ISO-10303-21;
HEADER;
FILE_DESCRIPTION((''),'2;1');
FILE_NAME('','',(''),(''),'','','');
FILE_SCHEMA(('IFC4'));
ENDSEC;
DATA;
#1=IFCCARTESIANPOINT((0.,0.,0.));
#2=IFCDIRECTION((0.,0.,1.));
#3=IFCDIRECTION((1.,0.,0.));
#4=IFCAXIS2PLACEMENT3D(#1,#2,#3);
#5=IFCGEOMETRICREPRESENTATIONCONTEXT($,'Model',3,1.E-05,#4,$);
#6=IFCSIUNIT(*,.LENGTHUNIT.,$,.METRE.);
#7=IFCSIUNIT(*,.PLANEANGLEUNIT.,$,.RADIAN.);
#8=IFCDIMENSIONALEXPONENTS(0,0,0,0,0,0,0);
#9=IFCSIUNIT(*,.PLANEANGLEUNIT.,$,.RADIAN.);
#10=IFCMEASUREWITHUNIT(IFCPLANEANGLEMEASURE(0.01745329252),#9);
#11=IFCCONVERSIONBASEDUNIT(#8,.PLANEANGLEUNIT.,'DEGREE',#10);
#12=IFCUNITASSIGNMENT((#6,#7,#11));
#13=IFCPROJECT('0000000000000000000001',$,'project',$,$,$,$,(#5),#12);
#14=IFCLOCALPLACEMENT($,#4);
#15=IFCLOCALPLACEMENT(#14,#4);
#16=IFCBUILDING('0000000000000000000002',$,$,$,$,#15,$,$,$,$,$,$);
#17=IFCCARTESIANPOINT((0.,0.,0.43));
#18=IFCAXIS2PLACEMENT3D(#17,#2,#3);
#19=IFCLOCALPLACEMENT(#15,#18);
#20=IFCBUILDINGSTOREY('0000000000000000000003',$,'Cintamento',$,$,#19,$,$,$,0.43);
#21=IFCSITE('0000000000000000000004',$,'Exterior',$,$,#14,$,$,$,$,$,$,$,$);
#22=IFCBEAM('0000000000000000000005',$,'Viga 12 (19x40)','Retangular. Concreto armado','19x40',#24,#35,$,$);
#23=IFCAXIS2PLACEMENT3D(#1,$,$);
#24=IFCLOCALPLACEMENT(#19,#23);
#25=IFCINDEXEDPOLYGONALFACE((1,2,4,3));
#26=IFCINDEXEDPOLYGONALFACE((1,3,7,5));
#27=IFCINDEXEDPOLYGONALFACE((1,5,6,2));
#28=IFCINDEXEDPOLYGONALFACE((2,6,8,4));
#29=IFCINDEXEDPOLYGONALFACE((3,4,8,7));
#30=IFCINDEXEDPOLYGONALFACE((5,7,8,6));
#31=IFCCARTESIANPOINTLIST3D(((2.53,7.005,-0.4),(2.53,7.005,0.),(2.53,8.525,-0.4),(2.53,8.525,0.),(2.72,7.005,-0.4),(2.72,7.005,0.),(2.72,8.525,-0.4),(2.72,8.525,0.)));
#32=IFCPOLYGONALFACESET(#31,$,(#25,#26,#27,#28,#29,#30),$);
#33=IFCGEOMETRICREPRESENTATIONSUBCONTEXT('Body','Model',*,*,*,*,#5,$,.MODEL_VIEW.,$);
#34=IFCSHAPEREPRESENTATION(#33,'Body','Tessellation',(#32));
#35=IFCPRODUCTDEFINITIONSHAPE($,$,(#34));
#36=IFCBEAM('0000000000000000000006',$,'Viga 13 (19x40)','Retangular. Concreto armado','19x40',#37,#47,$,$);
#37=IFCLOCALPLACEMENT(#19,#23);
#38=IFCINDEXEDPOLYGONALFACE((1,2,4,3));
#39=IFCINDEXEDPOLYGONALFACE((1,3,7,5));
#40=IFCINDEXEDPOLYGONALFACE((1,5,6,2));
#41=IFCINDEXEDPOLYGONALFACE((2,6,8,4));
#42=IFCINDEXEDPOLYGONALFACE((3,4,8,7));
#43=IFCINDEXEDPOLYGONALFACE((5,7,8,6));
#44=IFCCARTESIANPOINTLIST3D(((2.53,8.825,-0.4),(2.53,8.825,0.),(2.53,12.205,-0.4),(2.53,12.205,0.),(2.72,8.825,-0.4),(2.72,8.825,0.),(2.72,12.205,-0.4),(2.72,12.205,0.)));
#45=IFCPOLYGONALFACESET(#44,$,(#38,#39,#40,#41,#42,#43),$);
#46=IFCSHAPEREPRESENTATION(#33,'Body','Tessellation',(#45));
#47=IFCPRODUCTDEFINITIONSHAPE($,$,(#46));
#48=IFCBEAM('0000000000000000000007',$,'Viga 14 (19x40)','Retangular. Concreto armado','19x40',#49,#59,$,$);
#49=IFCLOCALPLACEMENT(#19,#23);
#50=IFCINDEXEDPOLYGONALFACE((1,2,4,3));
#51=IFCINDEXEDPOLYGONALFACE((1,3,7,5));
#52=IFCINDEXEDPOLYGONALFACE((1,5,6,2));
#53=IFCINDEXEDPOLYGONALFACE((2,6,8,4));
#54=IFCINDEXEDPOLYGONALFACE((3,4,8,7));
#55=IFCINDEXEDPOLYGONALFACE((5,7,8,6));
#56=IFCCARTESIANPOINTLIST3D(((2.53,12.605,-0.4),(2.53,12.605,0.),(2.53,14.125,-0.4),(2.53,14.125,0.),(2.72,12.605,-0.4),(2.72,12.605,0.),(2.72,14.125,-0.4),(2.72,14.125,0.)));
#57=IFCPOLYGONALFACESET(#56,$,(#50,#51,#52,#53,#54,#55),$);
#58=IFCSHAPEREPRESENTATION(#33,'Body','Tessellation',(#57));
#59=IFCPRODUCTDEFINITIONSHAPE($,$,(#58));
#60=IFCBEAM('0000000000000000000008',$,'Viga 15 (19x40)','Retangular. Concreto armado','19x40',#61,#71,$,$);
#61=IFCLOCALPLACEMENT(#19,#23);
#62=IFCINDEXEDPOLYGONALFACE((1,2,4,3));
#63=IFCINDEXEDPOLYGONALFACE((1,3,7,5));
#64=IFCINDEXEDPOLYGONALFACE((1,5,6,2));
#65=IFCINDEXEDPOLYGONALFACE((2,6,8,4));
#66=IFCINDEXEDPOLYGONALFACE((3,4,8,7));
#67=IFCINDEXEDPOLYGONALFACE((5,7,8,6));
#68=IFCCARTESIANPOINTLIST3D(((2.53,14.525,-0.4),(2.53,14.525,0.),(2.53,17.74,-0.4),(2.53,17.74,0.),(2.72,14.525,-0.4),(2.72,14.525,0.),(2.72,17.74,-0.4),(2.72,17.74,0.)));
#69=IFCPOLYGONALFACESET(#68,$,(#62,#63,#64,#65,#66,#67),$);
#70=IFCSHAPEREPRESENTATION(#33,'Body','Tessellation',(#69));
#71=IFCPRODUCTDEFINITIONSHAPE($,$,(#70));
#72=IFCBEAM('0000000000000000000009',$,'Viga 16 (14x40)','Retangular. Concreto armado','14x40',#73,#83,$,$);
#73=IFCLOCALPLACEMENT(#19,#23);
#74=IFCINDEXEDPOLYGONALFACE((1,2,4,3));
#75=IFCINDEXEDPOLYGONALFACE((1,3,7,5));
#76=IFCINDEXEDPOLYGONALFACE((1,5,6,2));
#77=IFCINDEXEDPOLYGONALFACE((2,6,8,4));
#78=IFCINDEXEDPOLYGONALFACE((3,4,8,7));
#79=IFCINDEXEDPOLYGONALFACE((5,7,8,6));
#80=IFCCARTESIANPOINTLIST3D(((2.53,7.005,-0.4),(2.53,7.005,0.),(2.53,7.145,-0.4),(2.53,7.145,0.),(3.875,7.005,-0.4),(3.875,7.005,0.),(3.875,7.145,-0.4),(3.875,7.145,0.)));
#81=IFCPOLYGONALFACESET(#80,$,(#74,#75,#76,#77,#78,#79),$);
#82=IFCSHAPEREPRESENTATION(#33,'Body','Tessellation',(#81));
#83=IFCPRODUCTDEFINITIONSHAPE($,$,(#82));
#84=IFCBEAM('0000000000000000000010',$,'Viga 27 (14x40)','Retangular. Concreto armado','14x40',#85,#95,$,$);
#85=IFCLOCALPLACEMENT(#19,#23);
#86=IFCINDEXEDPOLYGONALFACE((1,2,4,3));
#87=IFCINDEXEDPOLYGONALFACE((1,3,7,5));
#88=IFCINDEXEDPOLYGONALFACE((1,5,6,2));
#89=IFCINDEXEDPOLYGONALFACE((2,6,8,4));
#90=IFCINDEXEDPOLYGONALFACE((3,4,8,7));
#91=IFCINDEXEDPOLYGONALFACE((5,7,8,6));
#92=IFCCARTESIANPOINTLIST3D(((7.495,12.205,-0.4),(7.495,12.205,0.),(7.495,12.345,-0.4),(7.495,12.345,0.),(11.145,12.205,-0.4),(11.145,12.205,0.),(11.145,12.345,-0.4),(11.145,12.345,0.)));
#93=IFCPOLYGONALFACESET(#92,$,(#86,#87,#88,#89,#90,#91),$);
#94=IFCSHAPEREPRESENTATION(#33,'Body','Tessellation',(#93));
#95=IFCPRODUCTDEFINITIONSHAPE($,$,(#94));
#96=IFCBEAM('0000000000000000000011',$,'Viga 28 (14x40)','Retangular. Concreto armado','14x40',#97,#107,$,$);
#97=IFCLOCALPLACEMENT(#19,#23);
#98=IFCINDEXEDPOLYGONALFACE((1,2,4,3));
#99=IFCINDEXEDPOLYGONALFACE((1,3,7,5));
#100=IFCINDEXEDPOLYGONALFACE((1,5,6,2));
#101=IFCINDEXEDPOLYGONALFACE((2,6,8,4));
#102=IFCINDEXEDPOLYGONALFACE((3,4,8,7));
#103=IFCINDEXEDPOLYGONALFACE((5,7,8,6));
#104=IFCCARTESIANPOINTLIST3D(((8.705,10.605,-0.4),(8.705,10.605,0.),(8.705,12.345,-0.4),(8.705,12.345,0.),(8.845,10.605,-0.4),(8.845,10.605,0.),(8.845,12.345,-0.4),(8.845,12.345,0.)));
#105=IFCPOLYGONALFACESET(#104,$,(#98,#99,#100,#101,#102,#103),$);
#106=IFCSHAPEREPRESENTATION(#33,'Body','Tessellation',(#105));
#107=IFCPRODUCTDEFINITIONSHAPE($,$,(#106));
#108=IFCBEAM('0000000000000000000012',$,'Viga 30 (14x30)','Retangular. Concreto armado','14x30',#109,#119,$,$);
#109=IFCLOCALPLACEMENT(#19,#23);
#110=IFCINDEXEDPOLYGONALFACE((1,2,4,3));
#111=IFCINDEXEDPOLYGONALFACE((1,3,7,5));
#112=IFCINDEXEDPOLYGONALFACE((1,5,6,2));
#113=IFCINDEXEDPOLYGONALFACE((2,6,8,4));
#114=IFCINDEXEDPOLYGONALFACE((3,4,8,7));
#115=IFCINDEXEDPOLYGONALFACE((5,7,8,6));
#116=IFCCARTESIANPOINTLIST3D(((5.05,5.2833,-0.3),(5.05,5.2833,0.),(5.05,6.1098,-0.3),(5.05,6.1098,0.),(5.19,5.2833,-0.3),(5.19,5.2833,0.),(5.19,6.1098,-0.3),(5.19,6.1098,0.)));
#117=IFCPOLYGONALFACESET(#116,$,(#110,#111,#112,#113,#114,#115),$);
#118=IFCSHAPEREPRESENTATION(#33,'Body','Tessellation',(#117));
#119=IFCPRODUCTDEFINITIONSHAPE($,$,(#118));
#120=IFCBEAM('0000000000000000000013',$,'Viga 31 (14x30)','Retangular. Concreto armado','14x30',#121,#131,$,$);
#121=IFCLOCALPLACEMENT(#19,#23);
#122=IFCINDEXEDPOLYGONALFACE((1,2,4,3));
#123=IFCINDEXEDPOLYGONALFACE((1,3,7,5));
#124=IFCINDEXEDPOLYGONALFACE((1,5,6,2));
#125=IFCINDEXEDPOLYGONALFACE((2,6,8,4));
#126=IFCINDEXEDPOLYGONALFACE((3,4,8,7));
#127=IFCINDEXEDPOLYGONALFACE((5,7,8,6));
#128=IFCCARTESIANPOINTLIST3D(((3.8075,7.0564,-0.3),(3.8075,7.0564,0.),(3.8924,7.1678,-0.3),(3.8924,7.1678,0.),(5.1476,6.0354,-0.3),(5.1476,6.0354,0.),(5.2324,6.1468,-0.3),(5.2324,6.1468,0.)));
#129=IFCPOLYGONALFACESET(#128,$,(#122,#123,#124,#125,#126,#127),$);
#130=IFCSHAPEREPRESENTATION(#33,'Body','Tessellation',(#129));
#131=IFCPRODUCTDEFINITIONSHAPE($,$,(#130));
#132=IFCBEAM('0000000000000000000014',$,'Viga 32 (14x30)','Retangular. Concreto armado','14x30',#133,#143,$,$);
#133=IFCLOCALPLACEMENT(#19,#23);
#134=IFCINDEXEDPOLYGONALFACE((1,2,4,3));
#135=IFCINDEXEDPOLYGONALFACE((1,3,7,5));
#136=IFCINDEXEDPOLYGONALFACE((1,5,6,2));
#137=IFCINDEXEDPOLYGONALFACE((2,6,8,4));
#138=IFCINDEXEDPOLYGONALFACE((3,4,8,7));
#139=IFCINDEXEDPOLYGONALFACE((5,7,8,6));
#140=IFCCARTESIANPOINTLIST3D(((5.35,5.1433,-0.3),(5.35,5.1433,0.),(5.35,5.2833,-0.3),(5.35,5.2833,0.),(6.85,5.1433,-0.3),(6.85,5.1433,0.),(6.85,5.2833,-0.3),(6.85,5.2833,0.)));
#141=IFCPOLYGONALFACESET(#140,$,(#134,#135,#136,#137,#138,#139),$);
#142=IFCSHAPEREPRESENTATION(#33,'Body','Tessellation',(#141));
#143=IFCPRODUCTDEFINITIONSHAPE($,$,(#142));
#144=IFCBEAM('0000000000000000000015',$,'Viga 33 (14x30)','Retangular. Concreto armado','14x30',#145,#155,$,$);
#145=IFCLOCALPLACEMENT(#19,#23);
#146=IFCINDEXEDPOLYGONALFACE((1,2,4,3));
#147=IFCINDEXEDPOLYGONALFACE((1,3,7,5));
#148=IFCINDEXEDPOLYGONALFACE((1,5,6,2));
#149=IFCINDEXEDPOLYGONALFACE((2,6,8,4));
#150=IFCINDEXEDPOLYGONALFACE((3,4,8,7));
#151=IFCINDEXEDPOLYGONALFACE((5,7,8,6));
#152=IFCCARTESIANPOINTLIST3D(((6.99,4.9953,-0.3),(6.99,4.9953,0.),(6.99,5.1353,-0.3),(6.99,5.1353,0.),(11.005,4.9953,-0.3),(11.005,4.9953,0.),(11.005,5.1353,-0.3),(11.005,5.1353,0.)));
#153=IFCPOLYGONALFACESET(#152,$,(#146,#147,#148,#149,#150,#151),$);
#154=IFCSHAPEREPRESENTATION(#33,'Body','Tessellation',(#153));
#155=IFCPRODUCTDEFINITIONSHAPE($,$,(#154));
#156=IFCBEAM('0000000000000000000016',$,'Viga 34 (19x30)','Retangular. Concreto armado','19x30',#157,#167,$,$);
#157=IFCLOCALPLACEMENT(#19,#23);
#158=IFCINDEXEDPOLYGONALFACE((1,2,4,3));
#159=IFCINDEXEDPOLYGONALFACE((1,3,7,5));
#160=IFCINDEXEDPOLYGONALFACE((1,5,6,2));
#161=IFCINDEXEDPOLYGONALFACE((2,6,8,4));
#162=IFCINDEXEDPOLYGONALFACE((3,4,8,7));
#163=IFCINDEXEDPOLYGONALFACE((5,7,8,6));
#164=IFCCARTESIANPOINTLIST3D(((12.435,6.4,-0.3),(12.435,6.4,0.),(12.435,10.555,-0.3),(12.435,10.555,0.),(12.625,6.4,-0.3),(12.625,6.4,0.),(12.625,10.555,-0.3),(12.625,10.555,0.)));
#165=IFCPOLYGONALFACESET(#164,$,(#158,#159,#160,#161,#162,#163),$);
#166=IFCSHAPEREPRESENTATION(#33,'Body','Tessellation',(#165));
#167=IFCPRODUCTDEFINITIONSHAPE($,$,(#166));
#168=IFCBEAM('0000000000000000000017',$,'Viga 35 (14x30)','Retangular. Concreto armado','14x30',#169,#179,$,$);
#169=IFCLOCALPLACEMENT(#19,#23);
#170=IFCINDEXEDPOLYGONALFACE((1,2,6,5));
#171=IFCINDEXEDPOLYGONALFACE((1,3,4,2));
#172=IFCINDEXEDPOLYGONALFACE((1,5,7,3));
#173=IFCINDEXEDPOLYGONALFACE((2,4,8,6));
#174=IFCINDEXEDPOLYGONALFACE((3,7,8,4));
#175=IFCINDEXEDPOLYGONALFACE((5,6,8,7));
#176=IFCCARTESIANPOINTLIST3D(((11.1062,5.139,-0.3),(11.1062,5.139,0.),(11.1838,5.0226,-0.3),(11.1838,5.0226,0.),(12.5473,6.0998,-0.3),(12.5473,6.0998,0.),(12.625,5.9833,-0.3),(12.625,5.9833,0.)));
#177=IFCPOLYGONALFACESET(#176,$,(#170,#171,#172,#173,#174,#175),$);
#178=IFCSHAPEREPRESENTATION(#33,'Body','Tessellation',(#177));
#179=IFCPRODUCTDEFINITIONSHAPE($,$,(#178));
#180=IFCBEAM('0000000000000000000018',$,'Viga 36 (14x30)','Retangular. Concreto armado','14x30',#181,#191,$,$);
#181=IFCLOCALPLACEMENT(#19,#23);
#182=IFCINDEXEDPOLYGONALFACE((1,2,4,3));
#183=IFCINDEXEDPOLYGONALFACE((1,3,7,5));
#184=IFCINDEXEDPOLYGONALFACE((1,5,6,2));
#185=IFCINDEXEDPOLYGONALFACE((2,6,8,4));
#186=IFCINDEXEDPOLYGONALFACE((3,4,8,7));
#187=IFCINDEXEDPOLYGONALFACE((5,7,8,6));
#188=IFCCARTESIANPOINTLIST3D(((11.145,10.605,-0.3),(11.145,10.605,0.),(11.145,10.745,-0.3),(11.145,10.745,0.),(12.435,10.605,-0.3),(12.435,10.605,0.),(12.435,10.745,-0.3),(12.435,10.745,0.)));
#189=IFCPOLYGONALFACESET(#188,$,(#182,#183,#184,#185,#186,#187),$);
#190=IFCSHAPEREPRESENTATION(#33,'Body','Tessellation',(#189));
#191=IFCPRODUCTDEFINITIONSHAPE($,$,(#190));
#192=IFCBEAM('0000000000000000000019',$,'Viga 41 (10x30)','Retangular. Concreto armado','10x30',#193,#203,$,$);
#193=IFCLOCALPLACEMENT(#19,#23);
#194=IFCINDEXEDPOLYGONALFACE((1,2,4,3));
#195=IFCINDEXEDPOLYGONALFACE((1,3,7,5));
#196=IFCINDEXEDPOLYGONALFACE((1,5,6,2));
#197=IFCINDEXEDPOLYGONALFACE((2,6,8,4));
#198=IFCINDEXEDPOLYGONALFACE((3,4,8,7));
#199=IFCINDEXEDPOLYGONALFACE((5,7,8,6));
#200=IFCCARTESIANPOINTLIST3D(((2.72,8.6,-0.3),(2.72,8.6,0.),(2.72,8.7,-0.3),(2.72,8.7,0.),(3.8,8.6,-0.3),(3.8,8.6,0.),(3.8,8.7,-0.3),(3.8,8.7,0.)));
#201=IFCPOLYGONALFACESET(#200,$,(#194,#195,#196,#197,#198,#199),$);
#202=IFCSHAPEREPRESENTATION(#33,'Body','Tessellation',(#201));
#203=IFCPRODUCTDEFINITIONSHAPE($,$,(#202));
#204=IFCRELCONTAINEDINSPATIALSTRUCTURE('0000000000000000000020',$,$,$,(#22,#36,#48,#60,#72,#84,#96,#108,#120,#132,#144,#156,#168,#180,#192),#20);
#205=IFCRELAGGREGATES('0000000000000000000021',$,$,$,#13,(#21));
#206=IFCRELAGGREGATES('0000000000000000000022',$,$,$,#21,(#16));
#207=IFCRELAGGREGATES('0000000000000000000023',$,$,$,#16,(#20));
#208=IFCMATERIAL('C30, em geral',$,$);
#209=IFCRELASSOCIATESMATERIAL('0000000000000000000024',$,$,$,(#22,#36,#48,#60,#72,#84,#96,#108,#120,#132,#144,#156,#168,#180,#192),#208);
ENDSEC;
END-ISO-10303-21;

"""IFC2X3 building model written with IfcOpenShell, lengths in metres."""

from ifc_helpers import new_model, entity, si_unit, converted_unit, frame, frame_2d, origin_with_axes, place, context, subcontext, project, spatial, rectangle, extrude, material, element, save


model = new_model("IFC2X3")

# Units and contexts
model_context = context("Model", 3, precision=1e-05, world=origin_with_axes())
body_context = subcontext(model_context, "Body", "Model", "MODEL_VIEW")
ifc_project = project(units=[si_unit("LENGTHUNIT", "METRE"), si_unit("PLANEANGLEUNIT", "RADIAN"), converted_unit("PLANEANGLEUNIT", "DEGREE", entity("IfcPlaneAngleMeasure", 0.01745329252), si_unit("PLANEANGLEUNIT", "RADIAN"), dimensions=[0, 0, 0, 0, 0, 0, 0])], contexts=[model_context])

# Site, building, storey
site_placement = place(None, origin_with_axes())
site = spatial("IfcSite", under=ifc_project, at=site_placement, Name="Exterior")
building_placement = place(site_placement, origin_with_axes())
building = spatial("IfcBuilding", under=site, at=building_placement)
storey_placement = place(building_placement, frame((0.0, 0.0, 0.43), z_axis=(0.0, 0.0, 1.0), x_axis=(1.0, 0.0, 0.0)))
storey = spatial("IfcBuildingStorey", under=building, at=storey_placement, Name="Cintamento", Elevation=0.43)

# Beams
ifc_material_1 = material(Name="C30, em geral")
beam_1_placement = place(storey_placement, frame((2.625, 7.005, 0.0), z_axis=(0.0, 1.0, 0.0), x_axis=(-1.0, 0.0, 0.0)))
element("IfcBeam", 1, at=beam_1_placement, inside=storey, material=ifc_material_1, Name="Viga 12 (19x40)", Description="Retangular. Concreto armado", ObjectType="19x40", context=body_context, shape_type="SweptSolid", body=[
    extrude(rectangle(XDim=0.19, YDim=0.4, at=frame_2d((0.0, -0.2), x_axis=(1.0, 0.0))), origin_with_axes(), (0.0, 0.0, 1.0), 1.52),
])
beam_2_placement = place(storey_placement, frame((2.625, 8.825, 0.0), z_axis=(0.0, 1.0, 0.0), x_axis=(-1.0, 0.0, 0.0)))
element("IfcBeam", 2, at=beam_2_placement, inside=storey, material=ifc_material_1, Name="Viga 13 (19x40)", Description="Retangular. Concreto armado", ObjectType="19x40", context=body_context, shape_type="SweptSolid", body=[
    extrude(rectangle(XDim=0.19, YDim=0.4, at=frame_2d((0.0, -0.2), x_axis=(1.0, 0.0))), origin_with_axes(), (0.0, 0.0, 1.0), 3.38),
])
beam_3_placement = place(storey_placement, frame((2.625, 12.605, 0.0), z_axis=(0.0, 1.0, 0.0), x_axis=(-1.0, 0.0, 0.0)))
element("IfcBeam", 3, at=beam_3_placement, inside=storey, material=ifc_material_1, Name="Viga 14 (19x40)", Description="Retangular. Concreto armado", ObjectType="19x40", context=body_context, shape_type="SweptSolid", body=[
    extrude(rectangle(XDim=0.19, YDim=0.4, at=frame_2d((0.0, -0.2), x_axis=(1.0, 0.0))), origin_with_axes(), (0.0, 0.0, 1.0), 1.52),
])
beam_4_placement = place(storey_placement, frame((2.625, 14.525, 0.0), z_axis=(0.0, 1.0, 0.0), x_axis=(-1.0, 0.0, 0.0)))
element("IfcBeam", 4, at=beam_4_placement, inside=storey, material=ifc_material_1, Name="Viga 15 (19x40)", Description="Retangular. Concreto armado", ObjectType="19x40", context=body_context, shape_type="SweptSolid", body=[
    extrude(rectangle(XDim=0.19, YDim=0.4, at=frame_2d((0.0, -0.2), x_axis=(1.0, 0.0))), origin_with_axes(), (0.0, 0.0, 1.0), 3.215),
])
beam_5_placement = place(storey_placement, frame((2.53, 7.075, 0.0), z_axis=(1.0, 0.0, 0.0), x_axis=(0.0, 1.0, 0.0)))
element("IfcBeam", 5, at=beam_5_placement, inside=storey, material=ifc_material_1, Name="Viga 16 (14x40)", Description="Retangular. Concreto armado", ObjectType="14x40", context=body_context, shape_type="SweptSolid", body=[
    extrude(rectangle(XDim=0.14, YDim=0.4, at=frame_2d((0.0, -0.2), x_axis=(1.0, 0.0))), origin_with_axes(), (0.0, 0.0, 1.0), 1.345),
])
beam_6_placement = place(storey_placement, frame((7.495, 12.275, 0.0), z_axis=(1.0, 0.0, 0.0), x_axis=(0.0, 1.0, 0.0)))
element("IfcBeam", 6, at=beam_6_placement, inside=storey, material=ifc_material_1, Name="Viga 27 (14x40)", Description="Retangular. Concreto armado", ObjectType="14x40", context=body_context, shape_type="SweptSolid", body=[
    extrude(rectangle(XDim=0.14, YDim=0.4, at=frame_2d((0.0, -0.2), x_axis=(1.0, 0.0))), origin_with_axes(), (0.0, 0.0, 1.0), 3.65),
])
beam_7_placement = place(storey_placement, frame((8.775, 12.345, 0.0), z_axis=(0.0, -1.0, 0.0), x_axis=(1.0, 0.0, 0.0)))
element("IfcBeam", 7, at=beam_7_placement, inside=storey, material=ifc_material_1, Name="Viga 28 (14x40)", Description="Retangular. Concreto armado", ObjectType="14x40", context=body_context, shape_type="SweptSolid", body=[
    extrude(rectangle(XDim=0.14, YDim=0.4, at=frame_2d((0.0, -0.2), x_axis=(1.0, 0.0))), origin_with_axes(), (0.0, 0.0, 1.0), 1.74),
])
beam_8_placement = place(storey_placement, frame((5.12, 5.2833, 0.0), z_axis=(0.0, 1.0, 0.0), x_axis=(-1.0, 0.0, 0.0)))
element("IfcBeam", 8, at=beam_8_placement, inside=storey, material=ifc_material_1, Name="Viga 30 (14x30)", Description="Retangular. Concreto armado", ObjectType="14x30", context=body_context, shape_type="SweptSolid", body=[
    extrude(rectangle(XDim=0.14, YDim=0.3, at=frame_2d((0.0, -0.15), x_axis=(1.0, 0.0))), origin_with_axes(), (0.0, 0.0, 1.0), 0.8264),
])
beam_9_placement = place(storey_placement, frame((3.8499, 7.1121, 0.0), z_axis=(0.795432, -0.606043, 0.0), x_axis=(0.606043, 0.795432, 0.0)))
element("IfcBeam", 9, at=beam_9_placement, inside=storey, material=ifc_material_1, Name="Viga 31 (14x30)", Description="Retangular. Concreto armado", ObjectType="14x30", context=body_context, shape_type="SweptSolid", body=[
    extrude(rectangle(XDim=0.14, YDim=0.3, at=frame_2d((0.0, -0.15), x_axis=(1.0, 0.0))), origin_with_axes(), (0.0, 0.0, 1.0), 1.6847),
])
beam_10_placement = place(storey_placement, frame((5.35, 5.2133, 0.0), z_axis=(1.0, 0.0, 0.0), x_axis=(0.0, 1.0, 0.0)))
element("IfcBeam", 10, at=beam_10_placement, inside=storey, material=ifc_material_1, Name="Viga 32 (14x30)", Description="Retangular. Concreto armado", ObjectType="14x30", context=body_context, shape_type="SweptSolid", body=[
    extrude(rectangle(XDim=0.14, YDim=0.3, at=frame_2d((0.0, -0.15), x_axis=(1.0, 0.0))), origin_with_axes(), (0.0, 0.0, 1.0), 1.5),
])
beam_11_placement = place(storey_placement, frame((6.99, 5.0653, 0.0), z_axis=(1.0, 0.0, 0.0), x_axis=(0.0, 1.0, 0.0)))
element("IfcBeam", 11, at=beam_11_placement, inside=storey, material=ifc_material_1, Name="Viga 33 (14x30)", Description="Retangular. Concreto armado", ObjectType="14x30", context=body_context, shape_type="SweptSolid", body=[
    extrude(rectangle(XDim=0.14, YDim=0.3, at=frame_2d((0.0, -0.15), x_axis=(1.0, 0.0))), origin_with_axes(), (0.0, 0.0, 1.0), 4.015),
])
beam_12_placement = place(storey_placement, frame((12.53, 10.555, 0.0), z_axis=(0.0, -1.0, 0.0), x_axis=(1.0, 0.0, 0.0)))
element("IfcBeam", 12, at=beam_12_placement, inside=storey, material=ifc_material_1, Name="Viga 34 (19x30)", Description="Retangular. Concreto armado", ObjectType="19x30", context=body_context, shape_type="SweptSolid", body=[
    extrude(rectangle(XDim=0.19, YDim=0.3, at=frame_2d((0.0, -0.15), x_axis=(1.0, 0.0))), origin_with_axes(), (0.0, 0.0, 1.0), 4.155),
])
beam_13_placement = place(storey_placement, frame((11.145, 5.0808, 0.0), z_axis=(0.83205, 0.5547, 0.0), x_axis=(-0.5547, 0.83205, 0.0)))
element("IfcBeam", 13, at=beam_13_placement, inside=storey, material=ifc_material_1, Name="Viga 35 (14x30)", Description="Retangular. Concreto armado", ObjectType="14x30", context=body_context, shape_type="SweptSolid", body=[
    extrude(rectangle(XDim=0.14, YDim=0.3, at=frame_2d((0.0, -0.15), x_axis=(1.0, 0.0))), origin_with_axes(), (0.0, 0.0, 1.0), 1.7321),
])
beam_14_placement = place(storey_placement, frame((11.145, 10.675, 0.0), z_axis=(1.0, 0.0, 0.0), x_axis=(0.0, 1.0, 0.0)))
element("IfcBeam", 14, at=beam_14_placement, inside=storey, material=ifc_material_1, Name="Viga 36 (14x30)", Description="Retangular. Concreto armado", ObjectType="14x30", context=body_context, shape_type="SweptSolid", body=[
    extrude(rectangle(XDim=0.14, YDim=0.3, at=frame_2d((0.0, -0.15), x_axis=(1.0, 0.0))), origin_with_axes(), (0.0, 0.0, 1.0), 1.29),
])
beam_15_placement = place(storey_placement, frame((2.72, 8.65, 0.0), z_axis=(1.0, 0.0, 0.0), x_axis=(0.0, 1.0, 0.0)))
element("IfcBeam", 15, at=beam_15_placement, inside=storey, material=ifc_material_1, Name="Viga 41 (10x30)", Description="Retangular. Concreto armado", ObjectType="10x30", context=body_context, shape_type="SweptSolid", body=[
    extrude(rectangle(XDim=0.1, YDim=0.3, at=frame_2d((0.0, -0.15), x_axis=(1.0, 0.0))), origin_with_axes(), (0.0, 0.0, 1.0), 1.08),
])

save(model, "model.ifc")
